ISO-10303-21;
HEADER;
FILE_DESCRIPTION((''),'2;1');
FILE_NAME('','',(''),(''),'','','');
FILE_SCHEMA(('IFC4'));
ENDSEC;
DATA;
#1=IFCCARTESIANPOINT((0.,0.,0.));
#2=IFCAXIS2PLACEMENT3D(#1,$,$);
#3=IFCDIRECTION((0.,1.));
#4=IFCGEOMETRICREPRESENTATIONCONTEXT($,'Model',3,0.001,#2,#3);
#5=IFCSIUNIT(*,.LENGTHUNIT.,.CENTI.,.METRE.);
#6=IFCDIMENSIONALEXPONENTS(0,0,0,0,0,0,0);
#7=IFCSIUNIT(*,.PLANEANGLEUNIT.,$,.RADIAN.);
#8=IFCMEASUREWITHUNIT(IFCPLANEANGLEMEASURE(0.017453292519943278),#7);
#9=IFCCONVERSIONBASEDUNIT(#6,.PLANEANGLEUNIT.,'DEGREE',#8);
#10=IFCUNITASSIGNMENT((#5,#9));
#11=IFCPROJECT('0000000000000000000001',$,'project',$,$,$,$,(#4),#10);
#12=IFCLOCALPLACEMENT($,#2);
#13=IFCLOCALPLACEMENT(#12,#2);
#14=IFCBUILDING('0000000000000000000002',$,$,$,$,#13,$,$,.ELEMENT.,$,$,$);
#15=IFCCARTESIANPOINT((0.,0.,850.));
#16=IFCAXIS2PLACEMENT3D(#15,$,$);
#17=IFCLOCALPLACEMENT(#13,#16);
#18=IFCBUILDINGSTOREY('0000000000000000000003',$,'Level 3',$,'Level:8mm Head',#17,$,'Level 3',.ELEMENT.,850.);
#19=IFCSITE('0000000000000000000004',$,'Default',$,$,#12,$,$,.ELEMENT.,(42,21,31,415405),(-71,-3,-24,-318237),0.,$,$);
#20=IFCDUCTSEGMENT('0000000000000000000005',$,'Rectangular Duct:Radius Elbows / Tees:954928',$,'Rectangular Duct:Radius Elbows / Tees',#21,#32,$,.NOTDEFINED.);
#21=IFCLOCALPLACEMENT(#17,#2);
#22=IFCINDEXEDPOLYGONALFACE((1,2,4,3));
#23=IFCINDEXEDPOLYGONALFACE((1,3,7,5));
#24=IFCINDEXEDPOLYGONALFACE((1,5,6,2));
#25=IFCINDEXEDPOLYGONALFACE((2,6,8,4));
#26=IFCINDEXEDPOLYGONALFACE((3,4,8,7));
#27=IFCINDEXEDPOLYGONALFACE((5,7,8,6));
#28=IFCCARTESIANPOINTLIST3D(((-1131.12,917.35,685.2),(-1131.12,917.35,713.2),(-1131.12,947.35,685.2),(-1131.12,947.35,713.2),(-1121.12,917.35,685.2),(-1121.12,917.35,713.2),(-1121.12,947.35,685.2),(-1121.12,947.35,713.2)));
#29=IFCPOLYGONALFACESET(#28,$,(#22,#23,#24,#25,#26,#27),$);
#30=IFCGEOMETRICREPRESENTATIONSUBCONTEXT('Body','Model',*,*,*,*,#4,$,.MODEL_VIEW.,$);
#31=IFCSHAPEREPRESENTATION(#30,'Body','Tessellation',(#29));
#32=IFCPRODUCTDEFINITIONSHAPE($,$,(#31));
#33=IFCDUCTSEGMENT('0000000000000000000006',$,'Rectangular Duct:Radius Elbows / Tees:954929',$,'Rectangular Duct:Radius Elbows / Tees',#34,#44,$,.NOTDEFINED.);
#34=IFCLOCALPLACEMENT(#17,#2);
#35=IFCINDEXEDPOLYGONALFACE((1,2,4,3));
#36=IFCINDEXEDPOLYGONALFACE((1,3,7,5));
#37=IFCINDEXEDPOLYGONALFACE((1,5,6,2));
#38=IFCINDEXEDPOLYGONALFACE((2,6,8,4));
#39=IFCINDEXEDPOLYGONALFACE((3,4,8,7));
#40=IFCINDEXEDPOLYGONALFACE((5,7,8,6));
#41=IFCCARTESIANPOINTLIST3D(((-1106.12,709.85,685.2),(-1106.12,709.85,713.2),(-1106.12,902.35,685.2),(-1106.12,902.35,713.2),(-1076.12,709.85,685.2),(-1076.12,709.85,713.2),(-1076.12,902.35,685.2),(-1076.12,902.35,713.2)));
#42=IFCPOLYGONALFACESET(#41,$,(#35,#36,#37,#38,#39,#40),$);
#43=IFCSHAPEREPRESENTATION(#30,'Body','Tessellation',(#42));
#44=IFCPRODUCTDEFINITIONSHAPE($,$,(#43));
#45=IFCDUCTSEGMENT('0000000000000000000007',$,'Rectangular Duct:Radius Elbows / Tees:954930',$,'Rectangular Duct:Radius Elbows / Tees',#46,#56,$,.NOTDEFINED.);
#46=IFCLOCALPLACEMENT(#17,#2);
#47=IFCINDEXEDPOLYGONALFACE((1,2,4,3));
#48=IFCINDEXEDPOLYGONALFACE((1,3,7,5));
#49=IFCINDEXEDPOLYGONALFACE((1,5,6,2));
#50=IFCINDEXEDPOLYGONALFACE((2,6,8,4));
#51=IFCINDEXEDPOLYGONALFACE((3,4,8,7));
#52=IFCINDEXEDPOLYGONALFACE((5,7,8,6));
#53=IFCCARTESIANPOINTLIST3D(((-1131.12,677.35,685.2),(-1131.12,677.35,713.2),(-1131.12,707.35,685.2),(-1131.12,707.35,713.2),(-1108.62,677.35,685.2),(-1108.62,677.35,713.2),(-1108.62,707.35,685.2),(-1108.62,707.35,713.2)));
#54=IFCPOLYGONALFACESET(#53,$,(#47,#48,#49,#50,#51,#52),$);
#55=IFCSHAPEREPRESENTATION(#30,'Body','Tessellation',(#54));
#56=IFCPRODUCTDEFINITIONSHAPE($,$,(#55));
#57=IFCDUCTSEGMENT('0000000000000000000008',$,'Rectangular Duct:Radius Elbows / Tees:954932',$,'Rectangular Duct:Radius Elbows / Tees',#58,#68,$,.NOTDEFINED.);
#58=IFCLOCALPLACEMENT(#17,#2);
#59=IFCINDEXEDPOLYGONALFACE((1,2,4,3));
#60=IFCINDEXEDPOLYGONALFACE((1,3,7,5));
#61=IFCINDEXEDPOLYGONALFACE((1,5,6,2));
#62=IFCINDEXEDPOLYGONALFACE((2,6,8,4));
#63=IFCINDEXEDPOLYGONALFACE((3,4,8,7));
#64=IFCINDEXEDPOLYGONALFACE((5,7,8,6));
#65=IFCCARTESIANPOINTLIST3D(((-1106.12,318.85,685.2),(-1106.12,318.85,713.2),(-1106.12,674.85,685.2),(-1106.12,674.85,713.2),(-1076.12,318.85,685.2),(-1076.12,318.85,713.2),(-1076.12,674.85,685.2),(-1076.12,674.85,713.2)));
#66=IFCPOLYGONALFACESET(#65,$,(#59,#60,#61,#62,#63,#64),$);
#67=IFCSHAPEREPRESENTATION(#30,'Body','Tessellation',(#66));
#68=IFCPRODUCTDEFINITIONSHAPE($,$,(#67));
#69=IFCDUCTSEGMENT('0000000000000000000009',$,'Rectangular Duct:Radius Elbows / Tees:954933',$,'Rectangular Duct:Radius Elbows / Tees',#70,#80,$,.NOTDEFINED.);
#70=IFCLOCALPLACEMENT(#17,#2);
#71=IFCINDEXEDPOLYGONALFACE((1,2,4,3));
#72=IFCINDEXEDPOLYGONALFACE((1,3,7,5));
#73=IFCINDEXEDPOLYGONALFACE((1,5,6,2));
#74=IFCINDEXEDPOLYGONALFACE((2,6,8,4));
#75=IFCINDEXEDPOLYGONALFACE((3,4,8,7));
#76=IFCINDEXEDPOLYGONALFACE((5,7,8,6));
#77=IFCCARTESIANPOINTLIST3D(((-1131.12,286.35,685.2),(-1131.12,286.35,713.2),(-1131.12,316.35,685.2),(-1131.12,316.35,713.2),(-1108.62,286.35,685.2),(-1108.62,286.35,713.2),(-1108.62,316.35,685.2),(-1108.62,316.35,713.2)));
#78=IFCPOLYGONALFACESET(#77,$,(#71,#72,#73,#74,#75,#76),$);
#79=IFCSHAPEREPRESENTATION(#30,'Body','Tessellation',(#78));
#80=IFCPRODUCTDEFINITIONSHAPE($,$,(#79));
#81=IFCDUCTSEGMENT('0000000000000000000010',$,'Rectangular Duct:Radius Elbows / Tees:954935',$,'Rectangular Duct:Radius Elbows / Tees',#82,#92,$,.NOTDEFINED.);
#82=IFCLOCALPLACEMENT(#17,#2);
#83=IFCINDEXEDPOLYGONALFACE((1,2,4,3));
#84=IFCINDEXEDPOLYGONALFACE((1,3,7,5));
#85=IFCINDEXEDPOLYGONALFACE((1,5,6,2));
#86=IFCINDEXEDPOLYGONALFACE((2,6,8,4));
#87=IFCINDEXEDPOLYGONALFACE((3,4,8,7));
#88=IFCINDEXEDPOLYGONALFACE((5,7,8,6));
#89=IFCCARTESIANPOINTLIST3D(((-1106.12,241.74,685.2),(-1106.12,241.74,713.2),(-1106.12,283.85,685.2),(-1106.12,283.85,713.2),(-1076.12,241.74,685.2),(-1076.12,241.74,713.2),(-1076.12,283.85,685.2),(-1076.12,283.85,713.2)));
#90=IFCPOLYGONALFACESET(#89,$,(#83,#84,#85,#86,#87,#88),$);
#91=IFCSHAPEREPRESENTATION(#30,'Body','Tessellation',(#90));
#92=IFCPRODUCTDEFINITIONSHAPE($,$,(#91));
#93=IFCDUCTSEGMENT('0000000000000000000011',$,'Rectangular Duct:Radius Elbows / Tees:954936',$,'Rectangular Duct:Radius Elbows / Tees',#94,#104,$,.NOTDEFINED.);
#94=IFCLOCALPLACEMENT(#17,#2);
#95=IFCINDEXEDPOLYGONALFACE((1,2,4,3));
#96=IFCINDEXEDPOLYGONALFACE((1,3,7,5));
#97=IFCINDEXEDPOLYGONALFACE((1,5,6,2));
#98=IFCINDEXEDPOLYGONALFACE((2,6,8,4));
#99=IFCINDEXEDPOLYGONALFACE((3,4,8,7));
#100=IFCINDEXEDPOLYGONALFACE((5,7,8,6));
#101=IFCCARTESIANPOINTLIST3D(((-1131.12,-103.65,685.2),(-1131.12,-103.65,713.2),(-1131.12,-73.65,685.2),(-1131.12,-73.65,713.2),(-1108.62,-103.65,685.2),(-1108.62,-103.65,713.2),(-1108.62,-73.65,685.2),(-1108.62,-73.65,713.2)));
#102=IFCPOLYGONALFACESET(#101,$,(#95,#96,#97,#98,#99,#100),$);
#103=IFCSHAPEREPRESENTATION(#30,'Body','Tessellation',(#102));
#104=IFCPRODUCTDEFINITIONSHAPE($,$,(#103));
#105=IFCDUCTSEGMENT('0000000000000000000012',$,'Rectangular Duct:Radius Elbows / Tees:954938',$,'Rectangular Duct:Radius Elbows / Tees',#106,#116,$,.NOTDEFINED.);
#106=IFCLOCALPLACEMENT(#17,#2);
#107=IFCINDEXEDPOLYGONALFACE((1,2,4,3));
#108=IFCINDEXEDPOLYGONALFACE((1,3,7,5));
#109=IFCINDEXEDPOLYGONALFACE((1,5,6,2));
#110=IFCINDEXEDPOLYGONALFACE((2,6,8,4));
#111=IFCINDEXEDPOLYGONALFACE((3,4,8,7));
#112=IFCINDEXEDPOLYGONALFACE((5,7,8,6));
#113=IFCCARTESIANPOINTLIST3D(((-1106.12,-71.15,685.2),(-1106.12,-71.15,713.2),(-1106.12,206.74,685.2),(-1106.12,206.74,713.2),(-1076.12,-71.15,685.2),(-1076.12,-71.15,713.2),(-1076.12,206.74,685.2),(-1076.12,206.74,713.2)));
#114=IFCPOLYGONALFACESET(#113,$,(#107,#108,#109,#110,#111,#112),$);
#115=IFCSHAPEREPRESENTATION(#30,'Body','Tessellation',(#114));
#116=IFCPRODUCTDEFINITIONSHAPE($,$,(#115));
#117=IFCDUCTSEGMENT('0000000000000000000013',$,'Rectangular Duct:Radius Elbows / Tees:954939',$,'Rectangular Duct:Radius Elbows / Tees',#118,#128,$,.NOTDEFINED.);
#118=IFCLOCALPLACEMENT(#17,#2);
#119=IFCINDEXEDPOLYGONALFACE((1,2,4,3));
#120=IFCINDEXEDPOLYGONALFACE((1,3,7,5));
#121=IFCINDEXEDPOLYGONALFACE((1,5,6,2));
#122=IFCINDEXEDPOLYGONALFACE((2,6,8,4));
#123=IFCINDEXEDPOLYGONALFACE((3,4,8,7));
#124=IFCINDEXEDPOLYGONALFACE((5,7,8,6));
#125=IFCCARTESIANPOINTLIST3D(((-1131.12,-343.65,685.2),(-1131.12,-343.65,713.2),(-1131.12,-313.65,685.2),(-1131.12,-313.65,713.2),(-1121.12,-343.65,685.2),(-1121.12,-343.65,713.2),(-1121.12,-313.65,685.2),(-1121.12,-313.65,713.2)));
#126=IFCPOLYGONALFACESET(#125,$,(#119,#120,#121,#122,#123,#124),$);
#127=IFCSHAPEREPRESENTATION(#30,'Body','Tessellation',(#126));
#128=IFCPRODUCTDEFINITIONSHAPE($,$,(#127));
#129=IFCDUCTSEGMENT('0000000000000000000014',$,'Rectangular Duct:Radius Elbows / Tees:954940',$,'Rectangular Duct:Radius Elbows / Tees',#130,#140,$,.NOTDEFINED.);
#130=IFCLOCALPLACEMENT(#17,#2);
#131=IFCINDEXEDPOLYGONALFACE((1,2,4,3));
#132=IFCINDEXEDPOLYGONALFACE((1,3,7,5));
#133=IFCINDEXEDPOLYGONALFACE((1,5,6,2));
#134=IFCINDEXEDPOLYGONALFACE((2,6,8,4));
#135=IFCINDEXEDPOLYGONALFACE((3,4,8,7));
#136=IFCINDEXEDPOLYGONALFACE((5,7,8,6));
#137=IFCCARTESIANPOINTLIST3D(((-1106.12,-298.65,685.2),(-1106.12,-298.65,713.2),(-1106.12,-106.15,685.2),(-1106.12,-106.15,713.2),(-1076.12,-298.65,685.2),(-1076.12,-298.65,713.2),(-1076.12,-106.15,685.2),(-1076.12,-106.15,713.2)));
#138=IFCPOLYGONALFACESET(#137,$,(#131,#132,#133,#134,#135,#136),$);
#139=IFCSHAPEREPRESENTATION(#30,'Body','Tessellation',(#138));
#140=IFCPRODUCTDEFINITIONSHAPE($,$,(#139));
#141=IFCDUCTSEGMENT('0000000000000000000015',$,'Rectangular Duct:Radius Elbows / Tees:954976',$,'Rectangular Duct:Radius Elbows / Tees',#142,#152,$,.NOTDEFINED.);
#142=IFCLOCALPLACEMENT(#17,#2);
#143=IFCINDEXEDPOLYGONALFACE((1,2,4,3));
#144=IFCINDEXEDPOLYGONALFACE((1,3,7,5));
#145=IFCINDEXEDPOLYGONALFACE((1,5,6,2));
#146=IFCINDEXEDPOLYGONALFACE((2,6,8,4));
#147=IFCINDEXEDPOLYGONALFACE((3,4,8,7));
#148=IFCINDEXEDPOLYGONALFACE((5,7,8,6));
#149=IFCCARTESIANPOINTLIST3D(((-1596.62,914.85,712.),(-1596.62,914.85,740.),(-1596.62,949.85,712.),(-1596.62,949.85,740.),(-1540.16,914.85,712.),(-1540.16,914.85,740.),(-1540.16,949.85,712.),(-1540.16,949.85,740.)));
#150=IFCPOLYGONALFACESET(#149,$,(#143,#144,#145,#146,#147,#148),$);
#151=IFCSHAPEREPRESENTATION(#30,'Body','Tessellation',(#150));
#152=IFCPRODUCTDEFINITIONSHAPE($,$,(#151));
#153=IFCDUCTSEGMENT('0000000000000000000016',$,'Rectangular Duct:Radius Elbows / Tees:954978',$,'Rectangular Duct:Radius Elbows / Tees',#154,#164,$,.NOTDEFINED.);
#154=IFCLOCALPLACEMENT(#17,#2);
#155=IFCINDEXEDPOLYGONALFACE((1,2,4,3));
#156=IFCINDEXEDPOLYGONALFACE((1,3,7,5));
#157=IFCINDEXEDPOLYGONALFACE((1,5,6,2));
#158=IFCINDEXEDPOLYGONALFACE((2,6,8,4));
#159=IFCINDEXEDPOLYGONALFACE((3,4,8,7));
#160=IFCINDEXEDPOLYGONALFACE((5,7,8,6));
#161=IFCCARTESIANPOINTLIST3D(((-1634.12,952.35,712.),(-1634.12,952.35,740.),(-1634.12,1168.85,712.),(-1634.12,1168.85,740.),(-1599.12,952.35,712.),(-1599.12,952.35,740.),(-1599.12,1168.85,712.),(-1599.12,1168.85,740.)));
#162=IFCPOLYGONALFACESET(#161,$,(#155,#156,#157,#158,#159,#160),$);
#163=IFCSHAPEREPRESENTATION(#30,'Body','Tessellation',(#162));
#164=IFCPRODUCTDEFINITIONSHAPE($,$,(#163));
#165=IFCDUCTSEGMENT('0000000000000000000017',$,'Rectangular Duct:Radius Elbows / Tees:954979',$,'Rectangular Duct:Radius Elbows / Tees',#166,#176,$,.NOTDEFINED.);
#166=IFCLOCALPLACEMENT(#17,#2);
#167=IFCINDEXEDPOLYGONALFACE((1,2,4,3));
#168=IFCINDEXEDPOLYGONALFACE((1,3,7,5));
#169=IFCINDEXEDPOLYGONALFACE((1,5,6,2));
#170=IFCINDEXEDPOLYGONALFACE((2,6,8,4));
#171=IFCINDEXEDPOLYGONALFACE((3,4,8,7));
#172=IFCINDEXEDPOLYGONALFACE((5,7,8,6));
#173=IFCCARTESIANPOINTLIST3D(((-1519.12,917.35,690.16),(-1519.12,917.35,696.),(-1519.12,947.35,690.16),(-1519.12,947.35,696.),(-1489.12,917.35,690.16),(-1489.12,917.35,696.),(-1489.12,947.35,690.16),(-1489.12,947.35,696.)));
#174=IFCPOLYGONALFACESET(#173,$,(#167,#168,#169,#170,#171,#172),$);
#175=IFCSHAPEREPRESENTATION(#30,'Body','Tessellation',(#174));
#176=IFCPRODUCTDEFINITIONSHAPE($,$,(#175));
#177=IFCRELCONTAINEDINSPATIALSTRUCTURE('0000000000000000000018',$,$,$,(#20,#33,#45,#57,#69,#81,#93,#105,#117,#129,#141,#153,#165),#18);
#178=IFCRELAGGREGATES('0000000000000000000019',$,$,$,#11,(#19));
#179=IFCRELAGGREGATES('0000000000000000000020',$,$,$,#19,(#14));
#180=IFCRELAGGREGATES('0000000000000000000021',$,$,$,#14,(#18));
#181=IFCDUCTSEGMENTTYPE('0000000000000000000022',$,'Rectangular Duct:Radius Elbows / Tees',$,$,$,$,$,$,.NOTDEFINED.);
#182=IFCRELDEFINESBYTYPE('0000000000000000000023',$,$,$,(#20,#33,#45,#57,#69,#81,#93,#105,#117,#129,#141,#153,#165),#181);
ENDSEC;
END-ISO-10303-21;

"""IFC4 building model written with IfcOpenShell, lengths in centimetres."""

from ifc_helpers import new_model, entity, si_unit, converted_unit, direction, frame, origin, place, context, subcontext, project, spatial, indexed_curve, outline, extrude, type_object, element, save


model = new_model("IFC4")

# Units and contexts
model_context = context("Model", 3, precision=0.001, world=origin(), true_north=direction((0.0, 1.0)))
body_context = subcontext(model_context, "Body", "Model", "MODEL_VIEW")
ifc_project = project(units=[si_unit("LENGTHUNIT", "METRE", prefix="CENTI"), converted_unit("PLANEANGLEUNIT", "DEGREE", entity("IfcPlaneAngleMeasure", 0.017453292519943278), si_unit("PLANEANGLEUNIT", "RADIAN"), dimensions=[0, 0, 0, 0, 0, 0, 0])], contexts=[model_context])

# Site, building, storey
site_placement = place(None, origin())
site = spatial("IfcSite", under=ifc_project, at=site_placement, Name="Default", CompositionType="ELEMENT", RefLatitude=(42, 21, 31, 415405), RefLongitude=(-71, -3, -24, -318237), RefElevation=0.0)
building_placement = place(site_placement, origin())
building = spatial("IfcBuilding", under=site, at=building_placement, CompositionType="ELEMENT")
storey_placement = place(building_placement, frame((0.0, 0.0, 850.0)))
storey = spatial("IfcBuildingStorey", under=building, at=storey_placement, Name="Level 3", ObjectType="Level:8mm Head", LongName="Level 3", CompositionType="ELEMENT", Elevation=850.0)

# Duct segments
duct_segment_type = type_object("IfcDuctSegmentType", Name="Rectangular Duct:Radius Elbows / Tees", PredefinedType="NOTDEFINED")
duct_segment_1_placement = place(storey_placement, origin())
element("IfcDuctSegment", 1, at=duct_segment_1_placement, inside=storey, type_object=duct_segment_type, Name="Rectangular Duct:Radius Elbows / Tees:954928", ObjectType="Rectangular Duct:Radius Elbows / Tees", PredefinedType="NOTDEFINED", context=body_context, shape_type="SweptSolid", body=[
    extrude(outline(indexed_curve([(-5.0, -15.0), (5.0, -15.0), (5.0, 15.0), (-5.0, 15.0), (-5.0, -15.0)], self_intersect=False)), frame((-1126.12, 932.35, 685.2), z_axis=(0.0, 0.0, 1.0), x_axis=(-1.0, 0.0, 0.0)), (0.0, 0.0, 1.0), 28.0),
])
duct_segment_2_placement = place(storey_placement, origin())
element("IfcDuctSegment", 2, at=duct_segment_2_placement, inside=storey, type_object=duct_segment_type, Name="Rectangular Duct:Radius Elbows / Tees:954929", ObjectType="Rectangular Duct:Radius Elbows / Tees", PredefinedType="NOTDEFINED", context=body_context, shape_type="SweptSolid", body=[
    extrude(outline(indexed_curve([(-96.25, -15.0), (96.25, -15.0), (96.25, 15.0), (-96.25, 15.0), (-96.25, -15.0)], self_intersect=False)), frame((-1091.12, 806.1, 685.2), z_axis=(0.0, 0.0, 1.0), x_axis=(0.0, 1.0, 0.0)), (0.0, 0.0, 1.0), 28.0),
])
duct_segment_3_placement = place(storey_placement, origin())
element("IfcDuctSegment", 3, at=duct_segment_3_placement, inside=storey, type_object=duct_segment_type, Name="Rectangular Duct:Radius Elbows / Tees:954930", ObjectType="Rectangular Duct:Radius Elbows / Tees", PredefinedType="NOTDEFINED", context=body_context, shape_type="SweptSolid", body=[
    extrude(outline(indexed_curve([(-11.25, -15.0), (11.25, -15.0), (11.25, 15.0), (-11.25, 15.0), (-11.25, -15.0)], self_intersect=False)), frame((-1119.87, 692.35, 685.2), z_axis=(0.0, 0.0, 1.0), x_axis=(-1.0, 0.0, 0.0)), (0.0, 0.0, 1.0), 28.0),
])
duct_segment_4_placement = place(storey_placement, origin())
element("IfcDuctSegment", 4, at=duct_segment_4_placement, inside=storey, type_object=duct_segment_type, Name="Rectangular Duct:Radius Elbows / Tees:954932", ObjectType="Rectangular Duct:Radius Elbows / Tees", PredefinedType="NOTDEFINED", context=body_context, shape_type="SweptSolid", body=[
    extrude(outline(indexed_curve([(-178.0, -15.0), (178.0, -15.0), (178.0, 15.0), (-178.0, 15.0), (-178.0, -15.0)], self_intersect=False)), frame((-1091.12, 496.85, 685.2), z_axis=(0.0, 0.0, 1.0), x_axis=(0.0, 1.0, 0.0)), (0.0, 0.0, 1.0), 28.0),
])
duct_segment_5_placement = place(storey_placement, origin())
element("IfcDuctSegment", 5, at=duct_segment_5_placement, inside=storey, type_object=duct_segment_type, Name="Rectangular Duct:Radius Elbows / Tees:954933", ObjectType="Rectangular Duct:Radius Elbows / Tees", PredefinedType="NOTDEFINED", context=body_context, shape_type="SweptSolid", body=[
    extrude(outline(indexed_curve([(-11.25, -15.0), (11.25, -15.0), (11.25, 15.0), (-11.25, 15.0), (-11.25, -15.0)], self_intersect=False)), frame((-1119.87, 301.35, 685.2), z_axis=(0.0, 0.0, 1.0), x_axis=(-1.0, 0.0, 0.0)), (0.0, 0.0, 1.0), 28.0),
])
duct_segment_6_placement = place(storey_placement, origin())
element("IfcDuctSegment", 6, at=duct_segment_6_placement, inside=storey, type_object=duct_segment_type, Name="Rectangular Duct:Radius Elbows / Tees:954935", ObjectType="Rectangular Duct:Radius Elbows / Tees", PredefinedType="NOTDEFINED", context=body_context, shape_type="SweptSolid", body=[
    extrude(outline(indexed_curve([(-21.05, -15.0), (21.05, -15.0), (21.05, 15.0), (-21.05, 15.0), (-21.05, -15.0)], self_intersect=False)), frame((-1091.12, 262.79, 685.2), z_axis=(0.0, 0.0, 1.0), x_axis=(0.0, 1.0, 0.0)), (0.0, 0.0, 1.0), 28.0),
])
duct_segment_7_placement = place(storey_placement, origin())
element("IfcDuctSegment", 7, at=duct_segment_7_placement, inside=storey, type_object=duct_segment_type, Name="Rectangular Duct:Radius Elbows / Tees:954936", ObjectType="Rectangular Duct:Radius Elbows / Tees", PredefinedType="NOTDEFINED", context=body_context, shape_type="SweptSolid", body=[
    extrude(outline(indexed_curve([(-11.25, -15.0), (11.25, -15.0), (11.25, 15.0), (-11.25, 15.0), (-11.25, -15.0)], self_intersect=False)), frame((-1119.87, -88.65, 685.2), z_axis=(0.0, 0.0, 1.0), x_axis=(-1.0, 0.0, 0.0)), (0.0, 0.0, 1.0), 28.0),
])
duct_segment_8_placement = place(storey_placement, origin())
element("IfcDuctSegment", 8, at=duct_segment_8_placement, inside=storey, type_object=duct_segment_type, Name="Rectangular Duct:Radius Elbows / Tees:954938", ObjectType="Rectangular Duct:Radius Elbows / Tees", PredefinedType="NOTDEFINED", context=body_context, shape_type="SweptSolid", body=[
    extrude(outline(indexed_curve([(-138.95, -15.0), (138.95, -15.0), (138.95, 15.0), (-138.95, 15.0), (-138.95, -15.0)], self_intersect=False)), frame((-1091.12, 67.79, 685.2), z_axis=(0.0, 0.0, 1.0), x_axis=(0.0, -1.0, 0.0)), (0.0, 0.0, 1.0), 28.0),
])
duct_segment_9_placement = place(storey_placement, origin())
element("IfcDuctSegment", 9, at=duct_segment_9_placement, inside=storey, type_object=duct_segment_type, Name="Rectangular Duct:Radius Elbows / Tees:954939", ObjectType="Rectangular Duct:Radius Elbows / Tees", PredefinedType="NOTDEFINED", context=body_context, shape_type="SweptSolid", body=[
    extrude(outline(indexed_curve([(-5.0, -15.0), (5.0, -15.0), (5.0, 15.0), (-5.0, 15.0), (-5.0, -15.0)], self_intersect=False)), frame((-1126.12, -328.65, 685.2), z_axis=(0.0, 0.0, 1.0), x_axis=(-1.0, 0.0, 0.0)), (0.0, 0.0, 1.0), 28.0),
])
duct_segment_10_placement = place(storey_placement, origin())
element("IfcDuctSegment", 10, at=duct_segment_10_placement, inside=storey, type_object=duct_segment_type, Name="Rectangular Duct:Radius Elbows / Tees:954940", ObjectType="Rectangular Duct:Radius Elbows / Tees", PredefinedType="NOTDEFINED", context=body_context, shape_type="SweptSolid", body=[
    extrude(outline(indexed_curve([(-96.25, -15.0), (96.25, -15.0), (96.25, 15.0), (-96.25, 15.0), (-96.25, -15.0)], self_intersect=False)), frame((-1091.12, -202.4, 685.2), z_axis=(0.0, 0.0, 1.0), x_axis=(0.0, -1.0, 0.0)), (0.0, 0.0, 1.0), 28.0),
])
duct_segment_11_placement = place(storey_placement, origin())
element("IfcDuctSegment", 11, at=duct_segment_11_placement, inside=storey, type_object=duct_segment_type, Name="Rectangular Duct:Radius Elbows / Tees:954976", ObjectType="Rectangular Duct:Radius Elbows / Tees", PredefinedType="NOTDEFINED", context=body_context, shape_type="SweptSolid", body=[
    extrude(outline(indexed_curve([(-28.23, -17.5), (28.23, -17.5), (28.23, 17.5), (-28.23, 17.5), (-28.23, -17.5)], self_intersect=False)), frame((-1568.39, 932.35, 712.0), z_axis=(0.0, 0.0, 1.0), x_axis=(-1.0, 0.0, 0.0)), (0.0, 0.0, 1.0), 28.0),
])
duct_segment_12_placement = place(storey_placement, origin())
element("IfcDuctSegment", 12, at=duct_segment_12_placement, inside=storey, type_object=duct_segment_type, Name="Rectangular Duct:Radius Elbows / Tees:954978", ObjectType="Rectangular Duct:Radius Elbows / Tees", PredefinedType="NOTDEFINED", context=body_context, shape_type="SweptSolid", body=[
    extrude(outline(indexed_curve([(-108.25, -17.5), (108.25, -17.5), (108.25, 17.5), (-108.25, 17.5), (-108.25, -17.5)], self_intersect=False)), frame((-1616.62, 1060.6, 712.0), z_axis=(0.0, 0.0, 1.0), x_axis=(0.0, -1.0, 0.0)), (0.0, 0.0, 1.0), 28.0),
])
duct_segment_13_placement = place(storey_placement, origin())
element("IfcDuctSegment", 13, at=duct_segment_13_placement, inside=storey, type_object=duct_segment_type, Name="Rectangular Duct:Radius Elbows / Tees:954979", ObjectType="Rectangular Duct:Radius Elbows / Tees", PredefinedType="NOTDEFINED", context=body_context, shape_type="SweptSolid", body=[
    extrude(outline(indexed_curve([(-15.0, -15.0), (15.0, -15.0), (15.0, 15.0), (-15.0, 15.0), (-15.0, -15.0)], self_intersect=False)), frame((-1504.12, 932.35, 690.16)), (0.0, 0.0, 1.0), 5.84),
])

save(model, "model.ifc")
